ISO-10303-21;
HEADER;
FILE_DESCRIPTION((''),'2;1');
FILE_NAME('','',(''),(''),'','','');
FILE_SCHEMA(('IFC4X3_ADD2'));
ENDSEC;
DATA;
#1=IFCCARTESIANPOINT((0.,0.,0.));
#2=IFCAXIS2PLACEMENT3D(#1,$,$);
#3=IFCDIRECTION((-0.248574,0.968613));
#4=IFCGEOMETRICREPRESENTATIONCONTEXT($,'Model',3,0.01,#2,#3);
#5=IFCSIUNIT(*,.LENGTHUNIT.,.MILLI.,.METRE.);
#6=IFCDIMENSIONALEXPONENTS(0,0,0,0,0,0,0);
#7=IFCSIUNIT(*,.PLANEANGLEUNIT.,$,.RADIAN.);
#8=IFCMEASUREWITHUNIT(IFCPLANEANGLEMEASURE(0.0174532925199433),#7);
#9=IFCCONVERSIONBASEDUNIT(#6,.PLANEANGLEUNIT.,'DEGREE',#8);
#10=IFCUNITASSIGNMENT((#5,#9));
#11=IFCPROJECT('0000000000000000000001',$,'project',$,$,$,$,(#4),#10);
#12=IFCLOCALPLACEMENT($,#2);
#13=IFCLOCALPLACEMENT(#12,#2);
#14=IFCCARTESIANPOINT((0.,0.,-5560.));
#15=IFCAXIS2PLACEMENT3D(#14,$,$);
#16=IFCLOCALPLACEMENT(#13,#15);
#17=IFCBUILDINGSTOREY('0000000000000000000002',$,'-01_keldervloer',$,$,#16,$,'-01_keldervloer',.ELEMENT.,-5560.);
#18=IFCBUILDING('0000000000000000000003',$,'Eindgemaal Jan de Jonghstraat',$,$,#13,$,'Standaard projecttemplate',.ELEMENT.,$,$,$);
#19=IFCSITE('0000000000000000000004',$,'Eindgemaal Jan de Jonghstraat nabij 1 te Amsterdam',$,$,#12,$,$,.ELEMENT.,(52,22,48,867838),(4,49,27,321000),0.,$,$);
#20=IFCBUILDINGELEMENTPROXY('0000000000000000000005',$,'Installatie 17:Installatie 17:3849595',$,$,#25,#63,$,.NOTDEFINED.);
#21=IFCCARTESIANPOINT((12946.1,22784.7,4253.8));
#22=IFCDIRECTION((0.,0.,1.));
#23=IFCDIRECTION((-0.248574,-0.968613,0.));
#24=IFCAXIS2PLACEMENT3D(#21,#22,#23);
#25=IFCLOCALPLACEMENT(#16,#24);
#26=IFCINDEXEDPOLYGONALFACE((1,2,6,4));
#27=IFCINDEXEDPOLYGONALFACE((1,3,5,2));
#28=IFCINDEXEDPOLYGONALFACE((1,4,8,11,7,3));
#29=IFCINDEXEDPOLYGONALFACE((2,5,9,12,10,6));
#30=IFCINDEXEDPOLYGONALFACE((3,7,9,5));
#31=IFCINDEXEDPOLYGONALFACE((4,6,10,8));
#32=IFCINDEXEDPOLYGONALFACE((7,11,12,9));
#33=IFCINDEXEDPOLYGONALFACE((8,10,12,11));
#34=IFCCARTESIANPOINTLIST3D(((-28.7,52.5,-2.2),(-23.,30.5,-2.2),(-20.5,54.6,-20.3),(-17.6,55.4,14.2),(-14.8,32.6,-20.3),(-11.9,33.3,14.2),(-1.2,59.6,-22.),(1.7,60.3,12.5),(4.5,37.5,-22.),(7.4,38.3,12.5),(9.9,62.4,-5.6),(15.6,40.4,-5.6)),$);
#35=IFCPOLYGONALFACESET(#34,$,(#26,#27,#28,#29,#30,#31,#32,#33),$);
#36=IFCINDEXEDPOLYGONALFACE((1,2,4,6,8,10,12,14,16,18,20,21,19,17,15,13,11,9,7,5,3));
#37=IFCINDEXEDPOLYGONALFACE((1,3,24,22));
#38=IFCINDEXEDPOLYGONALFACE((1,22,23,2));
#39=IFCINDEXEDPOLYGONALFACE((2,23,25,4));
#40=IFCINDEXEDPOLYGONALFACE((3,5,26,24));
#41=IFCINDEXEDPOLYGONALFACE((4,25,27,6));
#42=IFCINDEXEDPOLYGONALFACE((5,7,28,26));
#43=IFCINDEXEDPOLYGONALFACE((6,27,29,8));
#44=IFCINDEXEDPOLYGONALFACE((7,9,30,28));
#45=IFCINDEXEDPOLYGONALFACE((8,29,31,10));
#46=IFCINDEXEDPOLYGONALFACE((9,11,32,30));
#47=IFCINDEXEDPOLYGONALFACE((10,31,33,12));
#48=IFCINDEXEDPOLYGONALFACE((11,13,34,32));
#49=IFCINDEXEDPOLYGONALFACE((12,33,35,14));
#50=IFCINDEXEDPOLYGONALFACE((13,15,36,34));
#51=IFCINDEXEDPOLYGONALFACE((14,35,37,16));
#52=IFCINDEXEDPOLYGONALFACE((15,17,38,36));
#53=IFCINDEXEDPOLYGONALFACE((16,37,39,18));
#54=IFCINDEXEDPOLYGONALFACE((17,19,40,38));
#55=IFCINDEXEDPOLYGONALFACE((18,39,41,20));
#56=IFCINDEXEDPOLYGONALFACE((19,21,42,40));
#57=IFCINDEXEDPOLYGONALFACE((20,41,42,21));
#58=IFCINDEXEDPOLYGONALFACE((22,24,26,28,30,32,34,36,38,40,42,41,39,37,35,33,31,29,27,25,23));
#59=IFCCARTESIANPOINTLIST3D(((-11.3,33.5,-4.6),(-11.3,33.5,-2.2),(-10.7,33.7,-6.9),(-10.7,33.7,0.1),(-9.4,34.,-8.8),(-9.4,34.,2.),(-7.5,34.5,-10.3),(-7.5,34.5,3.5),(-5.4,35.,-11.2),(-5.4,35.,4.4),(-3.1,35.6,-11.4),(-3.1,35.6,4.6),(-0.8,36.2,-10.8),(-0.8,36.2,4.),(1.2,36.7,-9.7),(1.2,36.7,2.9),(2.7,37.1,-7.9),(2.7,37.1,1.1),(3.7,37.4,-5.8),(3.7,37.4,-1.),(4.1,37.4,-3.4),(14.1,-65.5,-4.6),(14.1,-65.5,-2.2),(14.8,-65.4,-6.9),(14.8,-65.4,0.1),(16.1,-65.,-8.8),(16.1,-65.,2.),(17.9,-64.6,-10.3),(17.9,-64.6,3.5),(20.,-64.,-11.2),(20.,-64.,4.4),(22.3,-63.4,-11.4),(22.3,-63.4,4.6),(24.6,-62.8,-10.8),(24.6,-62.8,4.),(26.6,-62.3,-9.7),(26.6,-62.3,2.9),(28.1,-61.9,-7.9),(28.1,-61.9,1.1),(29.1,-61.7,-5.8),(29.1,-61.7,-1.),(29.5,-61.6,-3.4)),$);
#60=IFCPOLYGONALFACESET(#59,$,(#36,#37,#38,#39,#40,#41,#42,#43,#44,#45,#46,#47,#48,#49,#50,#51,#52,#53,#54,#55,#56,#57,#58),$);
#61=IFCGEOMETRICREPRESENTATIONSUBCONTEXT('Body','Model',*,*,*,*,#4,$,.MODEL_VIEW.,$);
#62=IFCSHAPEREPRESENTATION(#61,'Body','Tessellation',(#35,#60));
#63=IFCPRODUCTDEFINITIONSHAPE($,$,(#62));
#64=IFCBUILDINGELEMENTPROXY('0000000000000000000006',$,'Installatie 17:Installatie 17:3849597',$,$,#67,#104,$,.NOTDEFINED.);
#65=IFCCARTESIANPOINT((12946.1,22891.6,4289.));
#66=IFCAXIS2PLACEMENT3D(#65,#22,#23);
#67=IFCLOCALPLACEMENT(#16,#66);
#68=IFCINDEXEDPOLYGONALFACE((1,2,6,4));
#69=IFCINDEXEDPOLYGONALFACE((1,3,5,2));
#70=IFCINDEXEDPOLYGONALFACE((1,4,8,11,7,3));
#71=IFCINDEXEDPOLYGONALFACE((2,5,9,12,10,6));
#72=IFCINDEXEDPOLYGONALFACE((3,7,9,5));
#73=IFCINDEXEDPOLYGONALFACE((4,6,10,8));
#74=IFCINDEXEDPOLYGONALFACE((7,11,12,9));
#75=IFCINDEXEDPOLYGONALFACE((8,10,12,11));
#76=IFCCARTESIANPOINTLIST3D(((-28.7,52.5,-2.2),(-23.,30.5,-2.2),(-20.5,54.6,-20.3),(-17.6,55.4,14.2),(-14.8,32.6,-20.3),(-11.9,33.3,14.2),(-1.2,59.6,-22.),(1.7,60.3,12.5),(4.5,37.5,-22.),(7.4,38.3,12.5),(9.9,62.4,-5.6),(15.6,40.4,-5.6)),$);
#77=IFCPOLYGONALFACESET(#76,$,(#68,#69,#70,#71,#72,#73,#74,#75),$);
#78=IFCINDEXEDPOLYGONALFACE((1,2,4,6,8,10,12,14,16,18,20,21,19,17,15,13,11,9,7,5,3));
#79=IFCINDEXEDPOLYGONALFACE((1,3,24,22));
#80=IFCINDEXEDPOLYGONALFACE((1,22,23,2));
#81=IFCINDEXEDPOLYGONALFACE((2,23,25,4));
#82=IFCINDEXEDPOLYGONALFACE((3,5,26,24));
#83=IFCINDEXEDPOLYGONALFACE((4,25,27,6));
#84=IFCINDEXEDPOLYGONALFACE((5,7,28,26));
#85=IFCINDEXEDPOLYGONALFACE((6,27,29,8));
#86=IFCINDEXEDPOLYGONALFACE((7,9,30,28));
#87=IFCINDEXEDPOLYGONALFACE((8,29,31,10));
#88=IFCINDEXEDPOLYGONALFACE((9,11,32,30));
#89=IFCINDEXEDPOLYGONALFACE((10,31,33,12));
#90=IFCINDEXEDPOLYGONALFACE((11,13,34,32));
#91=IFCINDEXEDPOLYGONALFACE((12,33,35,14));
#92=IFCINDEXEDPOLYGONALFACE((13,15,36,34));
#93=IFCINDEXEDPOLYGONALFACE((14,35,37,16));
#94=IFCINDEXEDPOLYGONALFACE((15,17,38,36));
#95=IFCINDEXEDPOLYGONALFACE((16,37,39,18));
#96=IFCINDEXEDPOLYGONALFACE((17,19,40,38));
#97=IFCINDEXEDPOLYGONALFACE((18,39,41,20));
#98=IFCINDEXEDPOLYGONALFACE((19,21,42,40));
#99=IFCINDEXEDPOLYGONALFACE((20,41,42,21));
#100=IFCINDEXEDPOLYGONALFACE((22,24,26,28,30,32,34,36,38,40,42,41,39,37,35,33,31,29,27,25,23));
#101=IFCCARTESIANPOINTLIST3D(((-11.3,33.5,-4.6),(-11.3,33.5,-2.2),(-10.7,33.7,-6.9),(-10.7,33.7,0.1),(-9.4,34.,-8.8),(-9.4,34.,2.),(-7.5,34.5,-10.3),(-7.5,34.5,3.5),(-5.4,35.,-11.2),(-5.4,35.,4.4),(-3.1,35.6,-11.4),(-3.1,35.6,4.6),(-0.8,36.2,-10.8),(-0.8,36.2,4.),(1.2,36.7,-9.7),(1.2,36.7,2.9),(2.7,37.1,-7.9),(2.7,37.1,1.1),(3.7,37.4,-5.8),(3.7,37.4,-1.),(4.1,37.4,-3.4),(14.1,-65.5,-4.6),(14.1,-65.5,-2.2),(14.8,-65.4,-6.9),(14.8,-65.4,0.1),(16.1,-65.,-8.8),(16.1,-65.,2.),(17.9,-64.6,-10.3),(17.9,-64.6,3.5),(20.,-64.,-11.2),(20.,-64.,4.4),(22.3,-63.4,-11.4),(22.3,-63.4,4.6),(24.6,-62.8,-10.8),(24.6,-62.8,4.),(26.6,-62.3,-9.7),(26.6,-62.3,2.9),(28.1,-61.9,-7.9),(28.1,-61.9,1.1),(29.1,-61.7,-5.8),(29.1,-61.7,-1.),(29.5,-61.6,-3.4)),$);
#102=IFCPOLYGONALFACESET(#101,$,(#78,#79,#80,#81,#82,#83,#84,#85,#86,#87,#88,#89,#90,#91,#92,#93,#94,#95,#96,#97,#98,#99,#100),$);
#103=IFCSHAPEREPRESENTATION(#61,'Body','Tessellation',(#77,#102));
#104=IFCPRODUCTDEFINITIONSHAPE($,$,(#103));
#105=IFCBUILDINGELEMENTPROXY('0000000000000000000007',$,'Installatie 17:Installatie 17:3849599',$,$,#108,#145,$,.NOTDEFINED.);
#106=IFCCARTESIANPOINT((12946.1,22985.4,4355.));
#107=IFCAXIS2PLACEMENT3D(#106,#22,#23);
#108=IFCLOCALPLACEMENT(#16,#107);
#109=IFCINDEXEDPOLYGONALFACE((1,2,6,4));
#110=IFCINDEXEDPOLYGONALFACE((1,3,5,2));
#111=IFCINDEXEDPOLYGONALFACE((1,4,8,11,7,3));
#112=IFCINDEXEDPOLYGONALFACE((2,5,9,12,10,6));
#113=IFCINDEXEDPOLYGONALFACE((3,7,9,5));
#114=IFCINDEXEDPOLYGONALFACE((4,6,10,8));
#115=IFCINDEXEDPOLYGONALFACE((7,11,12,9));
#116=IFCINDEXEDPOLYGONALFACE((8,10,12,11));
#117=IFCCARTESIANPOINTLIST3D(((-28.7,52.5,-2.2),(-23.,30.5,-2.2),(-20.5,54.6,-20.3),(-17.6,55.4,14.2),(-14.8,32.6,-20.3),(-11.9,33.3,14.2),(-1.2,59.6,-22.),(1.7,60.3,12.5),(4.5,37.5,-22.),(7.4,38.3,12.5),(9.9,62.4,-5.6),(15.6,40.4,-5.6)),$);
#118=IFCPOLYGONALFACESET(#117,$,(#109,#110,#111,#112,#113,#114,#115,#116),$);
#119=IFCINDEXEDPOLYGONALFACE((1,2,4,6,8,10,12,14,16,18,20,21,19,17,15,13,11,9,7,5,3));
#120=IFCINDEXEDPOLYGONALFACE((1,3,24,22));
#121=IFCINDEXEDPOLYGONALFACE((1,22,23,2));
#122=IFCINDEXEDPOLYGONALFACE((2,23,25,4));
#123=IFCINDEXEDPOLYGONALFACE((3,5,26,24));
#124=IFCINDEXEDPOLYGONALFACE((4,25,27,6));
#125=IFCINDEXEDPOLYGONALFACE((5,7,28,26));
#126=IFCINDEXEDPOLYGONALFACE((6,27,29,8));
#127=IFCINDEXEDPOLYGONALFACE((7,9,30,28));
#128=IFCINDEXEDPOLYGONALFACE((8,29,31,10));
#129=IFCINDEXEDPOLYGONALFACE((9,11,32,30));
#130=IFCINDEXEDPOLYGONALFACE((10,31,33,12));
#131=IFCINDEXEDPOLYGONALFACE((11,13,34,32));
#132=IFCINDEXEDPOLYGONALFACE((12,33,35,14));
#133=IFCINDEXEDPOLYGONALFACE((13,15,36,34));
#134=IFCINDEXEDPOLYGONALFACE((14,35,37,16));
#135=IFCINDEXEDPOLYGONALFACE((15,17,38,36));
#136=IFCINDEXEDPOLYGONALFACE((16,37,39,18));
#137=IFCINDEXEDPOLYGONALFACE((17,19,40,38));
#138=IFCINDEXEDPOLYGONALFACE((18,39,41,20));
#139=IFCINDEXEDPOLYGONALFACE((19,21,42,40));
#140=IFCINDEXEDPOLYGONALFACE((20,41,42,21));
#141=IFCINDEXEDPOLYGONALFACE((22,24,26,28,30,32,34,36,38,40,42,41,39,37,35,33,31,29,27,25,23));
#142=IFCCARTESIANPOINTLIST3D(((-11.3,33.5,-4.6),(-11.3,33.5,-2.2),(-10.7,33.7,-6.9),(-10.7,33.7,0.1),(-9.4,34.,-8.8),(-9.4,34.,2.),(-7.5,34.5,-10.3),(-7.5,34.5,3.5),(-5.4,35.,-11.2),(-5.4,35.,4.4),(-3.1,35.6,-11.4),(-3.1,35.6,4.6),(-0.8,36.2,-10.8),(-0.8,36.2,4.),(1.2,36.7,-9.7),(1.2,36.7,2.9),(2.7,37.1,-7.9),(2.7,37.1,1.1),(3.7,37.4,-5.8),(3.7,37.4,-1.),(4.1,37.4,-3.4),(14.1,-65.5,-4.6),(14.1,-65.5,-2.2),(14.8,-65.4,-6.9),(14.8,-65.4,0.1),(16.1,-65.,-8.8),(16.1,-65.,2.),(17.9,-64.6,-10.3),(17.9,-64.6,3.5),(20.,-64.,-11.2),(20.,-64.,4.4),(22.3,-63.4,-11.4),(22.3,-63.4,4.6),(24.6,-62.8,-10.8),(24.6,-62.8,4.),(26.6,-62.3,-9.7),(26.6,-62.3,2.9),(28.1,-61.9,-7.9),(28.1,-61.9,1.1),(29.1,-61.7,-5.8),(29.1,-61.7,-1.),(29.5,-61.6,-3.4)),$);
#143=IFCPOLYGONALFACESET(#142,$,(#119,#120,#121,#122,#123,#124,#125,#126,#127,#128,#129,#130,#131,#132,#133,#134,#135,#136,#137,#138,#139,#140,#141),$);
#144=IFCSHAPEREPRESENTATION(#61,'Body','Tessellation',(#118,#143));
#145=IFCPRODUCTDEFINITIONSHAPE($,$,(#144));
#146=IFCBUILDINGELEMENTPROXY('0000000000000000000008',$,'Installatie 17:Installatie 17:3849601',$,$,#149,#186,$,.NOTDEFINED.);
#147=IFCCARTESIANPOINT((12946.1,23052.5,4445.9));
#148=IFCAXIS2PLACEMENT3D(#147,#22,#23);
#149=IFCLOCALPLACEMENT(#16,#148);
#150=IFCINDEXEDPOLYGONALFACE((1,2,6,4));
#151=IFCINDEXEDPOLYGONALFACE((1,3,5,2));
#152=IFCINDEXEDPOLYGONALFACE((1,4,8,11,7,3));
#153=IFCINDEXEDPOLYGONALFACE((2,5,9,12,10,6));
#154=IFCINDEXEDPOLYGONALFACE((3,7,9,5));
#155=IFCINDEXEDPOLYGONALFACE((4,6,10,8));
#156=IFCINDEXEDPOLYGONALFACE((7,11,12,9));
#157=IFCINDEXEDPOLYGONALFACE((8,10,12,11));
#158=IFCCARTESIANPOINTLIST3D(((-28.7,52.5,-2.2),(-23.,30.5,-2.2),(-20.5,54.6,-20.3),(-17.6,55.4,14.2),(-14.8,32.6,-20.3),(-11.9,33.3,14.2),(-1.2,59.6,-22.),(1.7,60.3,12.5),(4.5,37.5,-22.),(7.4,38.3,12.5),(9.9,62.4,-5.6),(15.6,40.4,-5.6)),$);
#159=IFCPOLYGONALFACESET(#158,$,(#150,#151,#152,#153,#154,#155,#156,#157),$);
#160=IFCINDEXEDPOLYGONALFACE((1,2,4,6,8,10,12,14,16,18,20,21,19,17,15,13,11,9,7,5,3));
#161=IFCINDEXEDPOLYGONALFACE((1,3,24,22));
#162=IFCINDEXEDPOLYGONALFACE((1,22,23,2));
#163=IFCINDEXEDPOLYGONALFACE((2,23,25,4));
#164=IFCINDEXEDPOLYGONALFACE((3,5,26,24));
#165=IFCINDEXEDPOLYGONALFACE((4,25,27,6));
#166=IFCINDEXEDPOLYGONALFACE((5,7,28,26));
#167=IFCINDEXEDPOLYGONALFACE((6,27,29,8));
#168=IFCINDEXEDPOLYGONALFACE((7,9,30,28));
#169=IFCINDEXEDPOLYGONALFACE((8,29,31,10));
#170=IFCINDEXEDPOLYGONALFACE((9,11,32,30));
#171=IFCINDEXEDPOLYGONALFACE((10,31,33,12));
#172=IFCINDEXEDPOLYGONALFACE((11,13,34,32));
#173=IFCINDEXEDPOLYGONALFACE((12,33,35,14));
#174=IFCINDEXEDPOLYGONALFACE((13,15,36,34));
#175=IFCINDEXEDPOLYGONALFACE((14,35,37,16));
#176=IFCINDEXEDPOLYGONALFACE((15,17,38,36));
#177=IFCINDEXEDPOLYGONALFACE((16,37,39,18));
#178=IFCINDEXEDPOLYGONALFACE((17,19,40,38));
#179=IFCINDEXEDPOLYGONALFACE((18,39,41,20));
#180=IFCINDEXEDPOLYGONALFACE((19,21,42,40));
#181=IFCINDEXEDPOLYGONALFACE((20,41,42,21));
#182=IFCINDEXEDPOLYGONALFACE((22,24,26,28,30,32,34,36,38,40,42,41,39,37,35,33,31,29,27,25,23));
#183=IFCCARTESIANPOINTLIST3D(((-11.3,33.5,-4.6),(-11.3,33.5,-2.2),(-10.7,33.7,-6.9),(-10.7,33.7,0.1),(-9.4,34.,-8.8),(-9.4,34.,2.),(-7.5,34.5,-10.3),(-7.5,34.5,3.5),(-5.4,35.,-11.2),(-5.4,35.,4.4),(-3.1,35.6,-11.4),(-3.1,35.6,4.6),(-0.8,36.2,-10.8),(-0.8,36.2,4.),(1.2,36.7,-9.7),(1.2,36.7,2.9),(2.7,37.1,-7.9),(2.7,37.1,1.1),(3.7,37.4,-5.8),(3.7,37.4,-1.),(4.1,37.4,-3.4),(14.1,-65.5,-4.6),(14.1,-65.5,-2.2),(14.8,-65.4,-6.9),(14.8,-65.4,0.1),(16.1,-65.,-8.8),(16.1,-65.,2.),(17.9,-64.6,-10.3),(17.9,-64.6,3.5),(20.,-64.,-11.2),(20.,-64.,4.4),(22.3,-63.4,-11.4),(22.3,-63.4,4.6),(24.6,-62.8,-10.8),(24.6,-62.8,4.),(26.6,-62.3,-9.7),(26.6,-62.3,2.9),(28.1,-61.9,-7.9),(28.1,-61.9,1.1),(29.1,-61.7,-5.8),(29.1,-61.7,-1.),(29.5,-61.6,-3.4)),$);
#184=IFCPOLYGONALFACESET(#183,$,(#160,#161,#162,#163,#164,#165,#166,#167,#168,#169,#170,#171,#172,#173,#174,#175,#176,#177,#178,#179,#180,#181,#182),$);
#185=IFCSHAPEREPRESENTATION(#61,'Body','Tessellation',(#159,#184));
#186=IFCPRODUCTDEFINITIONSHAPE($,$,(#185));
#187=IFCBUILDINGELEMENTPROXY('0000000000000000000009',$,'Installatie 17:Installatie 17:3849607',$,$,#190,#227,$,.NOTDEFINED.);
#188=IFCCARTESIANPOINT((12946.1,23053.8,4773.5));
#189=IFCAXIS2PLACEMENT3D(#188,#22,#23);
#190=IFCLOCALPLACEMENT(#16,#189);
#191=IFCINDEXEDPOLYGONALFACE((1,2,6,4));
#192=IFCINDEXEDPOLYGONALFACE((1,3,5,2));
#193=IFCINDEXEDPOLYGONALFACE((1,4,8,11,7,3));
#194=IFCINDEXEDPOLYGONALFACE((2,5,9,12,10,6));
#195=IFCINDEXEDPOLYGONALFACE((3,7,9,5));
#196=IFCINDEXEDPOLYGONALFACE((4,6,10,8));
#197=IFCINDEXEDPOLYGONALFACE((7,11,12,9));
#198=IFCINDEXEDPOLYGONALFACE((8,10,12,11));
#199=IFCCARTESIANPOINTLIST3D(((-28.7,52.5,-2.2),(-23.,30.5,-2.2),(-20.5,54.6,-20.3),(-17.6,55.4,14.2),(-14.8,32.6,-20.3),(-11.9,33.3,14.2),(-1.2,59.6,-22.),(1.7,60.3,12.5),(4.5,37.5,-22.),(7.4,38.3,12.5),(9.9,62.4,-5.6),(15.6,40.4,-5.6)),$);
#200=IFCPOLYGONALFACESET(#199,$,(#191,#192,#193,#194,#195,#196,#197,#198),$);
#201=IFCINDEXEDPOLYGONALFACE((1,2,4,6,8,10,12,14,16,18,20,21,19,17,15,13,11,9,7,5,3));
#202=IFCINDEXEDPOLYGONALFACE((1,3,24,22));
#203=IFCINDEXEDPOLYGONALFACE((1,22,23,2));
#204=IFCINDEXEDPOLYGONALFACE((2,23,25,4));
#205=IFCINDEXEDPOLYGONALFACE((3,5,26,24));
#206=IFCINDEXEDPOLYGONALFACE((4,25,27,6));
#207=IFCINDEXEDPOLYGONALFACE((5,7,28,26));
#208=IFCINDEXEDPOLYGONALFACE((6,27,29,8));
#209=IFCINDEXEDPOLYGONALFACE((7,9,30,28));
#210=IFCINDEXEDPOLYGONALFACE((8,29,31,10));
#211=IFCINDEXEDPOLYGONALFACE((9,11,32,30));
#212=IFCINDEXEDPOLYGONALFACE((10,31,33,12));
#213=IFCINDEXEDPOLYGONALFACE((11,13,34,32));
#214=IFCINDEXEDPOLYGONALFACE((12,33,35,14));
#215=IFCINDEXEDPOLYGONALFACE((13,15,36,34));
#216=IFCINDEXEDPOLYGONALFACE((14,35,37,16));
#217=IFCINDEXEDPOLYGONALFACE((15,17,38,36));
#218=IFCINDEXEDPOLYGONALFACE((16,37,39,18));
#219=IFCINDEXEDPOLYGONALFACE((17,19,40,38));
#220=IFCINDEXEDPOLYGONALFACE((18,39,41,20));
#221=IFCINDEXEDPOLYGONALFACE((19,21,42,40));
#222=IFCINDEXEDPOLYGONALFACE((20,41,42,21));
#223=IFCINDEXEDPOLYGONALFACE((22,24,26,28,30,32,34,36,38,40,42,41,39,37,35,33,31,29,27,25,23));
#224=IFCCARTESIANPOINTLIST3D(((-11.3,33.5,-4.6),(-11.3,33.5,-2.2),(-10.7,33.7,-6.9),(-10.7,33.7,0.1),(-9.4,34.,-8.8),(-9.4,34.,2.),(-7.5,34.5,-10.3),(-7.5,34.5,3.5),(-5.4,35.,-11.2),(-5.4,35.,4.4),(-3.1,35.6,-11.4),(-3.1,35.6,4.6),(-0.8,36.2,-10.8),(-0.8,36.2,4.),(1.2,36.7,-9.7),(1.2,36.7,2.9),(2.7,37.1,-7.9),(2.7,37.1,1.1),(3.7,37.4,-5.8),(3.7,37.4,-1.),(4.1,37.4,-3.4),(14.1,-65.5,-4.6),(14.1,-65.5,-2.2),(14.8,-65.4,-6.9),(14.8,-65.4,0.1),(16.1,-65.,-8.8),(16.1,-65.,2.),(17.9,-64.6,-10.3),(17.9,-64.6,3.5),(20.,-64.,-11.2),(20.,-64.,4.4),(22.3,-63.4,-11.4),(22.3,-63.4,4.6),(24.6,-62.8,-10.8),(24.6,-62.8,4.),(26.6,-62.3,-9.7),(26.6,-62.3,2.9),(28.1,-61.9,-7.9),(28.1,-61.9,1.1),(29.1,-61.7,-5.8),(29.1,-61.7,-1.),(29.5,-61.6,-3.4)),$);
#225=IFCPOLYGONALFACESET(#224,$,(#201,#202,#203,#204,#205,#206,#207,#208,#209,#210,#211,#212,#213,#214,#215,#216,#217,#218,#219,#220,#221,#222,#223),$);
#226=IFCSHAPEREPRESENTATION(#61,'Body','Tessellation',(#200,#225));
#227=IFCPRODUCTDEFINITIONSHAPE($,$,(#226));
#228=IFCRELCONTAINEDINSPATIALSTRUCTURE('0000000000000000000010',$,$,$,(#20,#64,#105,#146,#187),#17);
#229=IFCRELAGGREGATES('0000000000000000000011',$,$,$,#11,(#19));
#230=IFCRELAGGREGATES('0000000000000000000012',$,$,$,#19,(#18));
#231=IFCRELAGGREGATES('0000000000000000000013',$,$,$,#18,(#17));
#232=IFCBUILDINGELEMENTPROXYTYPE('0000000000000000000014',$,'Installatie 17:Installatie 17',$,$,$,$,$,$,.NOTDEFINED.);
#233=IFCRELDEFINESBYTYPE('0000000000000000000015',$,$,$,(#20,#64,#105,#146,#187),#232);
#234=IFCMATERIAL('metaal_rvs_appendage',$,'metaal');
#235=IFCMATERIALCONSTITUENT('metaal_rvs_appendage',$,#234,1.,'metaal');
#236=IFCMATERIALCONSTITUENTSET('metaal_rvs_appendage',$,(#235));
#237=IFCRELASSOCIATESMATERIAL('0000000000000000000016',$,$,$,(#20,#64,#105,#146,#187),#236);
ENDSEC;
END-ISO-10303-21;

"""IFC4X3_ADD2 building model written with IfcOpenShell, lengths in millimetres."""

from ifc_helpers import new_model, entity, si_unit, converted_unit, direction, frame, frame_2d, origin, place, context, subcontext, project, spatial, polyline, circle, outline, extrude, source, transform, mapped, material, constituent, constituent_set, type_object, type_shapes, element, save


model = new_model("IFC4X3_ADD2")

# Units and contexts
model_context = context("Model", 3, precision=0.01, world=origin(), true_north=direction((-0.248574, 0.968613)))
body_context = subcontext(model_context, "Body", "Model", "MODEL_VIEW")
ifc_project = project(units=[si_unit("LENGTHUNIT", "METRE", prefix="MILLI"), converted_unit("PLANEANGLEUNIT", "DEGREE", entity("IfcPlaneAngleMeasure", 0.0174532925199433), si_unit("PLANEANGLEUNIT", "RADIAN"), dimensions=[0, 0, 0, 0, 0, 0, 0])], contexts=[model_context])

# Site, building, storey
site_placement = place(None, origin())
site = spatial("IfcSite", under=ifc_project, at=site_placement, Name="Eindgemaal Jan de Jonghstraat nabij 1 te Amsterdam", CompositionType="ELEMENT", RefLatitude=(52, 22, 48, 867838), RefLongitude=(4, 49, 27, 321000), RefElevation=0.0)
building_placement = place(site_placement, origin())
building = spatial("IfcBuilding", under=site, at=building_placement, Name="Eindgemaal Jan de Jonghstraat", LongName="Standaard projecttemplate", CompositionType="ELEMENT")
storey_placement = place(building_placement, frame((0.0, 0.0, -5560.0)))
storey = spatial("IfcBuildingStorey", under=building, at=storey_placement, Name="-01_keldervloer", LongName="-01_keldervloer", CompositionType="ELEMENT", Elevation=-5560.0)

# Building element proxies
ifc_material_1 = material(Name="metaal_rvs_appendage", Category="metaal")
ifc_constituent_1 = constituent(ifc_material_1, Name="metaal_rvs_appendage", Category="metaal", fraction=1.0)
ifc_constituent_set_1 = constituent_set(constituents=[ifc_constituent_1], Name="metaal_rvs_appendage")
building_element_proxy_type_1 = type_object("IfcBuildingElementProxyType", Name="Installatie 17:Installatie 17", PredefinedType="NOTDEFINED")
shared_shape_1 = source(origin(), body_context, "Body", "SweptSolid", [
    extrude(outline(polyline([(-10.0, -17.3), (10.0, -17.3), (20.0, 0.0), (10.0, 17.3), (-10.0, 17.3), (-20.0, 0.0), (-10.0, -17.3)])), frame((-3.7, 35.4, -3.9), z_axis=(-0.248574, 0.968613, 0.0), x_axis=(-0.555573, -0.142576, -0.819152)), (0.0, 0.0, 1.0), 22.8),
    extrude(circle(Radius=8.0, at=frame_2d((0.0, 0.0), x_axis=(1.0, 0.0))), frame((21.7, -63.6, -3.4), z_axis=(-0.248574, 0.968613, 0.0), x_axis=(0.968613, 0.248574, 0.0)), (0.0, 0.0, 1.0), 102.2),
])
type_shapes(building_element_proxy_type_1, [shared_shape_1])
for number, where, z_axis, x_axis, name in (
    (1, (12946.1, 22784.7, 4253.8), (0.0, 0.0, 1.0), (-0.248574, -0.968613, 0.0), "Installatie 17:Installatie 17:3849595"),
    (2, (12946.1, 22891.6, 4289.0), (0.0, 0.0, 1.0), (-0.248574, -0.968613, 0.0), "Installatie 17:Installatie 17:3849597"),
    (3, (12946.1, 22985.4, 4355.0), (0.0, 0.0, 1.0), (-0.248574, -0.968613, 0.0), "Installatie 17:Installatie 17:3849599"),
    (4, (12946.1, 23052.5, 4445.9), (0.0, 0.0, 1.0), (-0.248574, -0.968613, 0.0), "Installatie 17:Installatie 17:3849601"),
    (5, (12946.1, 23053.8, 4773.5), (0.0, 0.0, 1.0), (-0.248574, -0.968613, 0.0), "Installatie 17:Installatie 17:3849607"),
):
    element("IfcBuildingElementProxy", number, at=place(storey_placement, frame(where, z_axis=z_axis, x_axis=x_axis)), inside=storey, type_object=building_element_proxy_type_1, material=ifc_constituent_set_1, Name=name, PredefinedType="NOTDEFINED", context=body_context, shape_type="MappedRepresentation", body=[
        mapped(shared_shape_1, transform((0.0, 0.0, 0.0), scale=1.0)),
    ])

save(model, "model.ifc")
